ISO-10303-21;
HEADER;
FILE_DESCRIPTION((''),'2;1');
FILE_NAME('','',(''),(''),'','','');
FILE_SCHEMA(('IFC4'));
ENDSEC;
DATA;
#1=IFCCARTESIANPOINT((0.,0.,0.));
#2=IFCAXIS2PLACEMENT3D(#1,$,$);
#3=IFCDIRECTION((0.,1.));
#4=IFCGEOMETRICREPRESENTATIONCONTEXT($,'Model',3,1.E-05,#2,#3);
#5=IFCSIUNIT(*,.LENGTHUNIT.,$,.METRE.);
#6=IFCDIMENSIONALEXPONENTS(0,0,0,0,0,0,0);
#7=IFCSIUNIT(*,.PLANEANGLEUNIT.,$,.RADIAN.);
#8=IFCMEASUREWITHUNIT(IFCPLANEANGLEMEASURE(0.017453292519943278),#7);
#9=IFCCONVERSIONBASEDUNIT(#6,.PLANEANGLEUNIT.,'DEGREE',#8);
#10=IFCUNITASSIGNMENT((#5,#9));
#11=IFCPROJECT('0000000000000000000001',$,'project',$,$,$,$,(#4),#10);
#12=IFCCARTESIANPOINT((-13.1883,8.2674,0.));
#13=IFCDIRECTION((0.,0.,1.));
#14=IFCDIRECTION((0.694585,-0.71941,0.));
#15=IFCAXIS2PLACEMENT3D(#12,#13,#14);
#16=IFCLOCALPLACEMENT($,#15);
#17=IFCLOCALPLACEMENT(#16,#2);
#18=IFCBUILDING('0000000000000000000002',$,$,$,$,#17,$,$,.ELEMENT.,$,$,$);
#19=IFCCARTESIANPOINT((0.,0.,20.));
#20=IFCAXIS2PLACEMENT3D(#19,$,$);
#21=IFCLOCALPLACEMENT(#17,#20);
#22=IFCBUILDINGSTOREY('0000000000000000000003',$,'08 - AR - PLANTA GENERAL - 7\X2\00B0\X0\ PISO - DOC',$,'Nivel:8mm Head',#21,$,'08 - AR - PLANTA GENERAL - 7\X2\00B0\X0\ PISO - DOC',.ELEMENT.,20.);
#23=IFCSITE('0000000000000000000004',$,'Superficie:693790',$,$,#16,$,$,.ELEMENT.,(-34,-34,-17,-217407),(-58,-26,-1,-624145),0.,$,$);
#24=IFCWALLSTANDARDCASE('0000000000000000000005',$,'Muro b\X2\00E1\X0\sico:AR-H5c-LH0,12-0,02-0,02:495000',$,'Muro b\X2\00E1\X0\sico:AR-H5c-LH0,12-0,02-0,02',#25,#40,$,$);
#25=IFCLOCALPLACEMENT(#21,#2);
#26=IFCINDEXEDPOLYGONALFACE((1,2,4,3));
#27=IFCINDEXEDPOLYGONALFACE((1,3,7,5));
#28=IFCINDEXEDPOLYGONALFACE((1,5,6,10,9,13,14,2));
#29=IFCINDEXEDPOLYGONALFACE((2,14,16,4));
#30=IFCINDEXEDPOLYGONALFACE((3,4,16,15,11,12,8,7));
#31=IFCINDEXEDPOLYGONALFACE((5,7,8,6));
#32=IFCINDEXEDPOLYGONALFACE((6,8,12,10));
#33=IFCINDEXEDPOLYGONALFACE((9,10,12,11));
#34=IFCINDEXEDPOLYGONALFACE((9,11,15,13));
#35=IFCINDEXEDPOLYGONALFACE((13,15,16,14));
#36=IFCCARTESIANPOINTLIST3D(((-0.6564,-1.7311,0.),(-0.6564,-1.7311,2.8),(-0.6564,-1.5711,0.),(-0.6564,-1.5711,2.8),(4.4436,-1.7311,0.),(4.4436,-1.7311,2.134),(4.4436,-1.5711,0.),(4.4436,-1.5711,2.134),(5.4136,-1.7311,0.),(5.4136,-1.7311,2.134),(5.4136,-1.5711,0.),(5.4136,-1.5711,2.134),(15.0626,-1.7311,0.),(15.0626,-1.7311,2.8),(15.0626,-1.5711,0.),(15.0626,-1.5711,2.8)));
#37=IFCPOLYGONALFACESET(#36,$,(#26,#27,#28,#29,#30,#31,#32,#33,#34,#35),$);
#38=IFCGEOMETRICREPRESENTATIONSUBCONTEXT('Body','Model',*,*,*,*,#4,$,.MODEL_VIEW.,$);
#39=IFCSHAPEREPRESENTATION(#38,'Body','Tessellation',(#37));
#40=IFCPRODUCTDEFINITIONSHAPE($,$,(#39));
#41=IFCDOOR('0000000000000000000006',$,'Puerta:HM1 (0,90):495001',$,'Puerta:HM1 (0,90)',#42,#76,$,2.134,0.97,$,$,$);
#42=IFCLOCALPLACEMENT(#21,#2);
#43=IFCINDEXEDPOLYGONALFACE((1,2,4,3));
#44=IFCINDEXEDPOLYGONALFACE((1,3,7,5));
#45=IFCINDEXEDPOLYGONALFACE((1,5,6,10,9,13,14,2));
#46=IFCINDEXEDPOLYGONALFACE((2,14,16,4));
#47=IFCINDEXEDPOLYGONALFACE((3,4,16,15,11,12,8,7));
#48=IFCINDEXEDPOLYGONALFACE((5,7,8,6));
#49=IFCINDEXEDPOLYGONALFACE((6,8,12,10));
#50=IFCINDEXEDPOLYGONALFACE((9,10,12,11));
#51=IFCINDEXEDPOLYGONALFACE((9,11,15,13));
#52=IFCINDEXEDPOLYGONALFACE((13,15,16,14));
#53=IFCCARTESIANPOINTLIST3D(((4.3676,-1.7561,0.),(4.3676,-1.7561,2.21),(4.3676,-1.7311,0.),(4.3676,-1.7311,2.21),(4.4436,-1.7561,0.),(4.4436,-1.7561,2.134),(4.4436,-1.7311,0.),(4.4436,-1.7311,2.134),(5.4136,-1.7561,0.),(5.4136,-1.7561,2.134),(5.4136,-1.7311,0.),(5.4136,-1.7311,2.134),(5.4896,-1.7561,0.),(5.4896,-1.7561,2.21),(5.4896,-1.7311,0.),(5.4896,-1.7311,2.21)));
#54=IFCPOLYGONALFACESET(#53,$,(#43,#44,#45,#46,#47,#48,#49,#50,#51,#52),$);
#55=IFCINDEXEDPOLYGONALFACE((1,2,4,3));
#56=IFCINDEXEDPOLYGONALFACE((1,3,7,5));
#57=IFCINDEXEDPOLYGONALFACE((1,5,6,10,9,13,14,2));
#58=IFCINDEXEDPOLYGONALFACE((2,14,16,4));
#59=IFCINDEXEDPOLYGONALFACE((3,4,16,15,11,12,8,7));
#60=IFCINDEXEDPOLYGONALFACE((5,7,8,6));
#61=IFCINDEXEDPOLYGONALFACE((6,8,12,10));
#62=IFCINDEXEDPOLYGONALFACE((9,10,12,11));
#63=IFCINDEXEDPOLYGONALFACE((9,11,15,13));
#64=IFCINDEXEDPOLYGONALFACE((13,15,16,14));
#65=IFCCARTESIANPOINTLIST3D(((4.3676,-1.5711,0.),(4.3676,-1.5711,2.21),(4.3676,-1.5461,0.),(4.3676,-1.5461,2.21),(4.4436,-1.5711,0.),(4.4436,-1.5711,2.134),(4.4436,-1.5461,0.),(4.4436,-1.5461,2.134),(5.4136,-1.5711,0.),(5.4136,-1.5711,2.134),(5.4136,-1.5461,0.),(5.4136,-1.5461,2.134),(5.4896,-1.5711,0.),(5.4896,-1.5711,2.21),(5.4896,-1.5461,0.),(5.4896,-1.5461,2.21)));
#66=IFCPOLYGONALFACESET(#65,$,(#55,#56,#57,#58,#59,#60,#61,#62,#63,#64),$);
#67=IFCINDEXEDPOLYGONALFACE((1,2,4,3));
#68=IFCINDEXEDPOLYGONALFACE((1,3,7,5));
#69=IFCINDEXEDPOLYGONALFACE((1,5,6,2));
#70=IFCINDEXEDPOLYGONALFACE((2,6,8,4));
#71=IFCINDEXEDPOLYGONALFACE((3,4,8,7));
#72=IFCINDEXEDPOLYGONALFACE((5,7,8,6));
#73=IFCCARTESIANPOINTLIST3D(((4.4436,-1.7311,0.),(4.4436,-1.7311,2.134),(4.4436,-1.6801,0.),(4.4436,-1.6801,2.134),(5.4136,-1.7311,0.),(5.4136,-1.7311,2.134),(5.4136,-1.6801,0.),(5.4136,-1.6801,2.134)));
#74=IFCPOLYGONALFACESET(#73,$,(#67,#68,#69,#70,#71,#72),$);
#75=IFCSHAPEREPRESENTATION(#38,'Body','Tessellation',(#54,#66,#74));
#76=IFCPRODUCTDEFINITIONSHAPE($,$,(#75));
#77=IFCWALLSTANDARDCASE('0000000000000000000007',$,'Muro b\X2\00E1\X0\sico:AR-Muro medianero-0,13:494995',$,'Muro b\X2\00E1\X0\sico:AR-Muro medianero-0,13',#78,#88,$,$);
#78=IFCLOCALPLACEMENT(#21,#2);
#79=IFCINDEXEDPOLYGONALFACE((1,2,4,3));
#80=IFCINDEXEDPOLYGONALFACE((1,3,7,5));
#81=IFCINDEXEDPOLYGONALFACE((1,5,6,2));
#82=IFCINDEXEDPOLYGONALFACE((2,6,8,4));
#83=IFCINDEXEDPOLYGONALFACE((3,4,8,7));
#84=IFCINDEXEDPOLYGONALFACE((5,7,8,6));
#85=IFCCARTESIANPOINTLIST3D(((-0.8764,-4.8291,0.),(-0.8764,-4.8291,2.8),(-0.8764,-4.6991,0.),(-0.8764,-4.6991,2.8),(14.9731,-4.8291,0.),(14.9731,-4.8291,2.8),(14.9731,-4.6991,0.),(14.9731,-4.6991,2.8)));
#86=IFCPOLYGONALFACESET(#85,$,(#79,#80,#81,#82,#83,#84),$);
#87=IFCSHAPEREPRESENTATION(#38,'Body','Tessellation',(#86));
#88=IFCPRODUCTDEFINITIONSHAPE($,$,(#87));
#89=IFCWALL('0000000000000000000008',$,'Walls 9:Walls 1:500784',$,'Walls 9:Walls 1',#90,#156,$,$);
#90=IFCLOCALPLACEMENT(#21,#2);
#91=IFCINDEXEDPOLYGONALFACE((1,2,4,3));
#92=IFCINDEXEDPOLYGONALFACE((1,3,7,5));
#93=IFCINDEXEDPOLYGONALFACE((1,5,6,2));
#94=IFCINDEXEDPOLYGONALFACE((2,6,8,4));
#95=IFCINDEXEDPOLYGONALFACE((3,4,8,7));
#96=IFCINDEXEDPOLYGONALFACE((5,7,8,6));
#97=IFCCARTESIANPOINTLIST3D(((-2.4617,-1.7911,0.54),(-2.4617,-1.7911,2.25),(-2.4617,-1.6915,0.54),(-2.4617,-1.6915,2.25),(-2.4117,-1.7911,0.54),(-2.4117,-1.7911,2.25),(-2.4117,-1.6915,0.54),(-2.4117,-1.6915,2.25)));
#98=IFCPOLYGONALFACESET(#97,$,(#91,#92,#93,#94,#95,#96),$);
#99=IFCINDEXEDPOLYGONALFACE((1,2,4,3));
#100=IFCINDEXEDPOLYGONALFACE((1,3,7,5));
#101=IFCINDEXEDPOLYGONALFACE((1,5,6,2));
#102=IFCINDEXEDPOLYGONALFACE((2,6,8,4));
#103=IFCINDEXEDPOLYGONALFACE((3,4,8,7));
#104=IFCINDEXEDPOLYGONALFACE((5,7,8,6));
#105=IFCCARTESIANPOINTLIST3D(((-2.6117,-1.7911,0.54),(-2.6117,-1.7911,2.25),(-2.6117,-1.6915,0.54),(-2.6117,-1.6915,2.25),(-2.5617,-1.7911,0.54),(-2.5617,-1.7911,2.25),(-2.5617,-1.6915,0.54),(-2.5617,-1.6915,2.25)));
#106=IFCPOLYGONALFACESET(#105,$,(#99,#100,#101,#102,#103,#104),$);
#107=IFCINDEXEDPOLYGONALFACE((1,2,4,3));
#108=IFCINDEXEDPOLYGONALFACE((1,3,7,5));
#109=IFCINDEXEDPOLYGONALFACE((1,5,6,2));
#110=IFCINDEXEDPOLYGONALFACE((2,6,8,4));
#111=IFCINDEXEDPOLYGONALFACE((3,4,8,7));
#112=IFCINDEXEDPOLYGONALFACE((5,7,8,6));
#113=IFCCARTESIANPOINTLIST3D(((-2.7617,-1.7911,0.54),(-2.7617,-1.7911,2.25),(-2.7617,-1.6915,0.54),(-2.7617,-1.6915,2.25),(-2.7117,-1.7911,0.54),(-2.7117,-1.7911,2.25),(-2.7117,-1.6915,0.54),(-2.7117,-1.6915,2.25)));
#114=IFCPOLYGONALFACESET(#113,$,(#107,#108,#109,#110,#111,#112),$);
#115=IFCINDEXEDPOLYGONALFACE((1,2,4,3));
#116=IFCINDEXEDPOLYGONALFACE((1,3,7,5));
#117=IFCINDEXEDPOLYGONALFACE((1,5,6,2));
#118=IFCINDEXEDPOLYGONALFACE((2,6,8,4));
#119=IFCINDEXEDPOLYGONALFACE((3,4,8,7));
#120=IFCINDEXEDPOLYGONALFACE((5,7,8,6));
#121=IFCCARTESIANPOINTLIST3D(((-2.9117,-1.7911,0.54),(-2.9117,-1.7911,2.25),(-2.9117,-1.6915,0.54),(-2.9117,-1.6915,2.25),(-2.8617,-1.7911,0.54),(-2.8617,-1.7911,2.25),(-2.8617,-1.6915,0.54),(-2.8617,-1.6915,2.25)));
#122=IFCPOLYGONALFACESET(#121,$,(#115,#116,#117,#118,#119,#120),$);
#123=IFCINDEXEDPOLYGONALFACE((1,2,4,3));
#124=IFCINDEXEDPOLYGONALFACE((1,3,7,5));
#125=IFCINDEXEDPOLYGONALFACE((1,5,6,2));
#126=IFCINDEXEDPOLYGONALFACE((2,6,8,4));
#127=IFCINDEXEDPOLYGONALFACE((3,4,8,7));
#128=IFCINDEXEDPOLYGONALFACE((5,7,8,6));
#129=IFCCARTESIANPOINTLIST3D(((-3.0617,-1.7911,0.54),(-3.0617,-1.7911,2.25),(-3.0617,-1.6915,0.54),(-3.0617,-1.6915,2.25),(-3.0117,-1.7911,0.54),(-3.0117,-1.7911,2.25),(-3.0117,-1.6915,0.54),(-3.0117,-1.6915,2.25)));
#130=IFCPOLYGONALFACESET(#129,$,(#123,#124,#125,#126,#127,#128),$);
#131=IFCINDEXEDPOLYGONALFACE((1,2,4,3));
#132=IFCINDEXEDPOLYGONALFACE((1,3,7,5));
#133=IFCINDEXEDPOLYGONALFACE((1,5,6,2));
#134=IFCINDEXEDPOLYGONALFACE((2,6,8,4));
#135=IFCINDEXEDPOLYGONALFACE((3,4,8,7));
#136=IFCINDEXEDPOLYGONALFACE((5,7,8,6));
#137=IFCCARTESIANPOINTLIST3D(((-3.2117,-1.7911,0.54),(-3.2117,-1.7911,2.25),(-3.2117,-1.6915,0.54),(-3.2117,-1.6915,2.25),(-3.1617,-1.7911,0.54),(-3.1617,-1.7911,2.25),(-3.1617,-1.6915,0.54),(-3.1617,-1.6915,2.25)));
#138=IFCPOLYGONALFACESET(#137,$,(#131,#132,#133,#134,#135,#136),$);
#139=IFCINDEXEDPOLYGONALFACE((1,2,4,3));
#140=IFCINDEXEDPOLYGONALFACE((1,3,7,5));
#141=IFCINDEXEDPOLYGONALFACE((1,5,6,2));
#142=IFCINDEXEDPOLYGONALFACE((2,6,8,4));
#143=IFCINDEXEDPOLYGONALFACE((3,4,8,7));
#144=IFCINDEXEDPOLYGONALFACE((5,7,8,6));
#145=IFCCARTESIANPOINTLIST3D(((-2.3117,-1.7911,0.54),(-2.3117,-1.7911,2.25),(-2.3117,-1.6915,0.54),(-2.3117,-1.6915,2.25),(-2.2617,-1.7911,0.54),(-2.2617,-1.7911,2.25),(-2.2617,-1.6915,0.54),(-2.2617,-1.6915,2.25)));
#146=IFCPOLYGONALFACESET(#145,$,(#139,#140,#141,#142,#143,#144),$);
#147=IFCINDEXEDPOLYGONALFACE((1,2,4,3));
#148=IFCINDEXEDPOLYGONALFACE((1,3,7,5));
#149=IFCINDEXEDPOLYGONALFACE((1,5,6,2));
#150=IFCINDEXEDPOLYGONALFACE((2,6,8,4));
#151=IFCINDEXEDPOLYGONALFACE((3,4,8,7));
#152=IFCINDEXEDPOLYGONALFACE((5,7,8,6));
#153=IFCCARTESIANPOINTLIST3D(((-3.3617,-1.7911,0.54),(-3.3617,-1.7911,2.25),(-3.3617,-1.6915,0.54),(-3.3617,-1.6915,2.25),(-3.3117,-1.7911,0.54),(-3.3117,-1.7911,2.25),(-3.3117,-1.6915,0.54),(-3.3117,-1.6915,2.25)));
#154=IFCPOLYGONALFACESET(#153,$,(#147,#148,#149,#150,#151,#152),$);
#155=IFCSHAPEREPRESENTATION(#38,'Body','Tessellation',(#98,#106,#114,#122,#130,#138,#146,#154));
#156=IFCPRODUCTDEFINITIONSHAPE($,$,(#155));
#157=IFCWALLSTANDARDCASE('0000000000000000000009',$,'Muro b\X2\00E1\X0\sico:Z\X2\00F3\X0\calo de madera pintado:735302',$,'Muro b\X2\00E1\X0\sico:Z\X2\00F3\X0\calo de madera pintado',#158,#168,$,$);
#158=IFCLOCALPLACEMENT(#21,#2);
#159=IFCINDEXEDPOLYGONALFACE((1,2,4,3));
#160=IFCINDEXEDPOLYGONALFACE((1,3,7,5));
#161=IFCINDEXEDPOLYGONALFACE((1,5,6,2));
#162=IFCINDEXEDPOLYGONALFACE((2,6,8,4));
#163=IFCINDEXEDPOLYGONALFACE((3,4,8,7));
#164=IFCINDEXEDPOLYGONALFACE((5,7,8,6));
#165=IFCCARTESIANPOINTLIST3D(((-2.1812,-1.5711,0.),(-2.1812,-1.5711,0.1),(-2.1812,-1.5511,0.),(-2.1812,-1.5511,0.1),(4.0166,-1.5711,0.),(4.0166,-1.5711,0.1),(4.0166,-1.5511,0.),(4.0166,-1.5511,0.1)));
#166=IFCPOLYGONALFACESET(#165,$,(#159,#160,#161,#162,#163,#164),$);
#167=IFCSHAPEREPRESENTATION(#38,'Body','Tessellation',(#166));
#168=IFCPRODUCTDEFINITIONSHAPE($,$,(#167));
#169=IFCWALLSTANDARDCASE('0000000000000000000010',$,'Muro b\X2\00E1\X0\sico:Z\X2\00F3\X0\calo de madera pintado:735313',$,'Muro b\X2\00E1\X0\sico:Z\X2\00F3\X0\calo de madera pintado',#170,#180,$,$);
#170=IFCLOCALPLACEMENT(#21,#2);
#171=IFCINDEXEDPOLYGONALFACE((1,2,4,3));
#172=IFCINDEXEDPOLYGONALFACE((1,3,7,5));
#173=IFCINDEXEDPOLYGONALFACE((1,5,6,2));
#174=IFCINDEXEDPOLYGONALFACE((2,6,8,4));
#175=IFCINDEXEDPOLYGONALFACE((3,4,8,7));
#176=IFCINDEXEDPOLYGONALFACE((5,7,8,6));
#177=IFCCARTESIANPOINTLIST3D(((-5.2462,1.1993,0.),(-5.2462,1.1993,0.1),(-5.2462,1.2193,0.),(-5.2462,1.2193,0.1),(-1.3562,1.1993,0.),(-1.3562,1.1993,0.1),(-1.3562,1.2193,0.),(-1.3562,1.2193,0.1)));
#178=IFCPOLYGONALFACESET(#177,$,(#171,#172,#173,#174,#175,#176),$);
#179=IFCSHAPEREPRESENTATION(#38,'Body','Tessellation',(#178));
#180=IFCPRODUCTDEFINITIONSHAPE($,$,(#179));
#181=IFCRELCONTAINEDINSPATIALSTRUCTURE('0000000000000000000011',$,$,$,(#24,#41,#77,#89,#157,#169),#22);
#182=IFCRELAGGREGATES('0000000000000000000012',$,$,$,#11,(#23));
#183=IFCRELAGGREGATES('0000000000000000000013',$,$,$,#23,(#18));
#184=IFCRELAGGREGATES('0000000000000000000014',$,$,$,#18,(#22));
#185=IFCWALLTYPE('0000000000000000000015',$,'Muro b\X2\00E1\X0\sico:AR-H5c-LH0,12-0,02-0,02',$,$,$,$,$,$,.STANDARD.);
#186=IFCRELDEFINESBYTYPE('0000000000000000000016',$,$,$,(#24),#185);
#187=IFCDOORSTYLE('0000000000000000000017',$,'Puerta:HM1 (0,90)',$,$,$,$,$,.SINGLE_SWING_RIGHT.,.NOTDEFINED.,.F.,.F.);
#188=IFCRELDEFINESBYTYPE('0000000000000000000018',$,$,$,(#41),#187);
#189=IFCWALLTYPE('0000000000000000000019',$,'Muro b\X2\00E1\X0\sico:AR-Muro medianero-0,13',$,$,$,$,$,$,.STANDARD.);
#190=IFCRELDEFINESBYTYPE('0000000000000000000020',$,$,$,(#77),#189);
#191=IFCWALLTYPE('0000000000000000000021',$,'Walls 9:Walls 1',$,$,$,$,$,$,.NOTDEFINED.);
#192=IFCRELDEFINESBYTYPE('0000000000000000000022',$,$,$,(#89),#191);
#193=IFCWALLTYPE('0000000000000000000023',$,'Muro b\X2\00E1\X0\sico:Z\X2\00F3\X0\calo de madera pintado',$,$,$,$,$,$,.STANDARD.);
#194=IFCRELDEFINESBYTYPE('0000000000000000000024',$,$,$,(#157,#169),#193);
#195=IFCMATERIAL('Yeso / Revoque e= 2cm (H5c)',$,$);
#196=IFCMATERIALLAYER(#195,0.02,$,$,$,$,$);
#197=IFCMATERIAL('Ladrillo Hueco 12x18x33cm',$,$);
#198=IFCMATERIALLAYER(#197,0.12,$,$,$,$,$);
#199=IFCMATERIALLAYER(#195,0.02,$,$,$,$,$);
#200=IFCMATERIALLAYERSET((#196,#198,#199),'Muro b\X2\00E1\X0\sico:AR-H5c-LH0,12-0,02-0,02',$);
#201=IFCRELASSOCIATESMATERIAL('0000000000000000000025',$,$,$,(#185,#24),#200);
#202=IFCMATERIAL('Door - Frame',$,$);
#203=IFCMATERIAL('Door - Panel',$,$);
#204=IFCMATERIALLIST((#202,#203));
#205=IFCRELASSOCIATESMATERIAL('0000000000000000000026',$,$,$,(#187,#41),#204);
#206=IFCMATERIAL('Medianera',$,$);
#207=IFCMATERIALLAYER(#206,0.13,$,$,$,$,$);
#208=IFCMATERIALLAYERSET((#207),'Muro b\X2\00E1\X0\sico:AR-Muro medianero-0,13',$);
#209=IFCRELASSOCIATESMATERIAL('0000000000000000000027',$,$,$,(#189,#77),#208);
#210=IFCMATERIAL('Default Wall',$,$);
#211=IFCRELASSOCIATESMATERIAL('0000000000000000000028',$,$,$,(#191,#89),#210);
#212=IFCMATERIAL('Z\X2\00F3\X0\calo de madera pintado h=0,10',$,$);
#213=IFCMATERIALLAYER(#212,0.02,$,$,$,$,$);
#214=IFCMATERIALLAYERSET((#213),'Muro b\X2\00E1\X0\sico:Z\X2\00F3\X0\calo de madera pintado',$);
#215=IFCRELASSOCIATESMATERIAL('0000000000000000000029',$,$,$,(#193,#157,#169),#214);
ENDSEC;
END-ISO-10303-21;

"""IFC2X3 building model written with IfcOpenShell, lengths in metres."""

from ifc_helpers import new_model, entity, si_unit, converted_unit, direction, frame, frame_2d, origin, place, context, subcontext, project, spatial, polyline, rectangle, outline, extrude, source, transform, mapped, material, material_list, layer, layer_set, layer_usage, type_object, type_shapes, element, fill, save


model = new_model("IFC2X3")

# Units and contexts
model_context = context("Model", 3, precision=1e-05, world=origin(), true_north=direction((0.0, 1.0)))
body_context = subcontext(model_context, "Body", "Model", "MODEL_VIEW")
ifc_project = project(units=[si_unit("LENGTHUNIT", "METRE"), converted_unit("PLANEANGLEUNIT", "DEGREE", entity("IfcPlaneAngleMeasure", 0.017453292519943278), si_unit("PLANEANGLEUNIT", "RADIAN"), dimensions=[0, 0, 0, 0, 0, 0, 0])], contexts=[model_context])

# Site, building, storey
site_placement = place(None, frame((-13.1883, 8.2674, 0.0), z_axis=(0.0, 0.0, 1.0), x_axis=(0.694585, -0.71941, 0.0)))
site = spatial("IfcSite", under=ifc_project, at=site_placement, Name="Superficie:693790", CompositionType="ELEMENT", RefLatitude=(-34, -34, -17, -217407), RefLongitude=(-58, -26, -1, -624145), RefElevation=0.0)
building_placement = place(site_placement, origin())
building = spatial("IfcBuilding", under=site, at=building_placement, CompositionType="ELEMENT")
storey_placement = place(building_placement, frame((0.0, 0.0, 20.0)))
storey = spatial("IfcBuildingStorey", under=building, at=storey_placement, Name="08 - AR - PLANTA GENERAL - 7° PISO - DOC", ObjectType="Nivel:8mm Head", LongName="08 - AR - PLANTA GENERAL - 7° PISO - DOC", CompositionType="ELEMENT", Elevation=20.0)

# Wall, opening, door
ifc_material_1 = material(Name="Yeso / Revoque e= 2cm (H5c)")
ifc_layer_1 = layer(ifc_material_1, 0.02)
ifc_material_2 = material(Name="Ladrillo Hueco 12x18x33cm")
ifc_layer_2 = layer(ifc_material_2, 0.12)
ifc_layer_3 = layer(ifc_material_1, 0.02)
ifc_layer_set_1 = layer_set([ifc_layer_1, ifc_layer_2, ifc_layer_3], Name="Muro básico:AR-H5c-LH0,12-0,02-0,02")
ifc_layer_usage_1 = layer_usage(ifc_layer_set_1, "AXIS2", "NEGATIVE", 0.08)
wall_type_1 = type_object("IfcWallType", Name="Muro básico:AR-H5c-LH0,12-0,02-0,02", PredefinedType="STANDARD", material=ifc_layer_set_1)
wall_1_placement = place(storey_placement, frame((-0.6564, -1.6511, 0.0)))
wall_1 = element("IfcWallStandardCase", 1, at=wall_1_placement, inside=storey, type_object=wall_type_1, material=ifc_layer_usage_1, Name="Muro básico:AR-H5c-LH0,12-0,02-0,02:495000", ObjectType="Muro básico:AR-H5c-LH0,12-0,02-0,02", context=body_context, shape_type="SweptSolid", body=[
    extrude(rectangle(XDim=15.719, YDim=0.16, at=frame_2d((7.8595, 0.0), x_axis=(1.0, 0.0))), origin(), (0.0, 0.0, 1.0), 2.8),
])
opening_1_placement = place(wall_1_placement, frame((6.07, 0.08, 0.0)))
opening_1 = element("IfcOpeningElement", 2, at=opening_1_placement, cuts=wall_1, ObjectType="Opening", context=body_context, shape_type="SweptSolid", body=[
    extrude(rectangle(XDim=0.97, YDim=2.134, at=frame_2d((1.067, 0.485), x_axis=(0.0, 1.0))), frame((0.0, 0.0, 0.0), z_axis=(0.0, -1.0, 0.0), x_axis=(0.0, 0.0, 1.0)), (0.0, 0.0, 1.0), 0.16),
])
ifc_material_3 = material(Name="Door - Frame")
ifc_material_4 = material(Name="Door - Panel")
ifc_material_list_1 = material_list([ifc_material_3, ifc_material_4])
door_style = type_object("IfcDoorStyle", Name="Puerta:HM1 (0,90)", ConstructionType="NOTDEFINED", OperationType="SINGLE_SWING_RIGHT", ParameterTakesPrecedence=False, Sizeable=False, material=ifc_material_list_1)
shared_shape_1 = source(origin(), body_context, "Body", "SweptSolid", [
    extrude(outline(polyline([(-0.561, -1.124), (0.561, -1.124), (0.561, 1.086), (0.485, 1.086), (0.485, -1.048), (-0.485, -1.048), (-0.485, 1.086), (-0.561, 1.086), (-0.561, -1.124)])), frame((0.485, 0.16, 1.086), z_axis=(0.0, 1.0, 0.0), x_axis=(1.0, 0.0, 0.0)), (0.0, 0.0, 1.0), 0.025),
    extrude(outline(polyline([(-1.124, -0.561), (1.086, -0.561), (1.086, -0.485), (-1.048, -0.485), (-1.048, 0.485), (1.086, 0.485), (1.086, 0.561), (-1.124, 0.561), (-1.124, -0.561)])), frame((0.485, -0.025, 1.086), z_axis=(0.0, 1.0, 0.0), x_axis=(0.0, 0.0, -1.0)), (0.0, 0.0, 1.0), 0.025),
    extrude(rectangle(XDim=0.051, YDim=0.97, at=frame_2d((0.0, 0.0), x_axis=(1.0, 0.0))), frame((0.485, 0.1345, 0.0), z_axis=(0.0, 0.0, 1.0), x_axis=(0.0, 1.0, 0.0)), (0.0, 0.0, 1.0), 2.134),
])
type_shapes(door_style, [shared_shape_1])
door_placement = place(opening_1_placement, frame((0.0, 0.0, 0.0), z_axis=(0.0, 0.0, 1.0), x_axis=(-1.0, 0.0, 0.0)))
door = element("IfcDoor", 3, at=door_placement, inside=storey, type_object=door_style, material=ifc_material_list_1, Name="Puerta:HM1 (0,90):495001", ObjectType="Puerta:HM1 (0,90)", OverallHeight=2.134, OverallWidth=0.97, context=body_context, shape_type="MappedRepresentation", body=[
    mapped(shared_shape_1, transform((0.0, 0.0, 0.0), scale=1.0)),
])
fill(opening_1, door)

# Walls
ifc_material_5 = material(Name="Medianera")
ifc_layer_4 = layer(ifc_material_5, 0.13)
ifc_layer_set_2 = layer_set([ifc_layer_4], Name="Muro básico:AR-Muro medianero-0,13")
ifc_layer_usage_2 = layer_usage(ifc_layer_set_2, "AXIS2", "POSITIVE", -0.065)
wall_type_2 = type_object("IfcWallType", Name="Muro básico:AR-Muro medianero-0,13", PredefinedType="STANDARD", material=ifc_layer_set_2)
wall_2_placement = place(storey_placement, frame((-0.8764, -4.7641, 0.0)))
element("IfcWallStandardCase", 4, at=wall_2_placement, inside=storey, type_object=wall_type_2, material=ifc_layer_usage_2, Name="Muro básico:AR-Muro medianero-0,13:494995", ObjectType="Muro básico:AR-Muro medianero-0,13", context=body_context, shape_type="SweptSolid", body=[
    extrude(rectangle(XDim=15.8495, YDim=0.13, at=frame_2d((7.9247, 0.0), x_axis=(-1.0, 0.0))), origin(), (0.0, 0.0, 1.0), 2.8),
])
ifc_material_6 = material(Name="Default Wall")
wall_type_3 = type_object("IfcWallType", Name="Walls 9:Walls 1", PredefinedType="NOTDEFINED", material=ifc_material_6)
wall_3_placement = place(storey_placement, frame((-3.3617, -1.7911, 0.54)))
element("IfcWall", 5, at=wall_3_placement, inside=storey, type_object=wall_type_3, material=ifc_material_6, Name="Walls 9:Walls 1:500784", ObjectType="Walls 9:Walls 1", context=body_context, shape_type="SweptSolid", body=[
    extrude(rectangle(XDim=0.05, YDim=0.0996, at=frame_2d((0.0, 0.0), x_axis=(1.0, 0.0))), frame((0.925, 0.0498, 0.0), z_axis=(0.0, 0.0, 1.0), x_axis=(-1.0, 0.0, 0.0)), (0.0, 0.0, 1.0), 1.71),
    extrude(rectangle(XDim=0.05, YDim=0.0996, at=frame_2d((0.0, 0.0), x_axis=(1.0, 0.0))), frame((0.775, 0.0498, 0.0), z_axis=(0.0, 0.0, 1.0), x_axis=(-1.0, 0.0, 0.0)), (0.0, 0.0, 1.0), 1.71),
    extrude(rectangle(XDim=0.05, YDim=0.0996, at=frame_2d((0.0, 0.0), x_axis=(1.0, 0.0))), frame((0.625, 0.0498, 0.0), z_axis=(0.0, 0.0, 1.0), x_axis=(-1.0, 0.0, 0.0)), (0.0, 0.0, 1.0), 1.71),
    extrude(rectangle(XDim=0.05, YDim=0.0996, at=frame_2d((0.0, 0.0), x_axis=(1.0, 0.0))), frame((0.475, 0.0498, 0.0), z_axis=(0.0, 0.0, 1.0), x_axis=(-1.0, 0.0, 0.0)), (0.0, 0.0, 1.0), 1.71),
    extrude(rectangle(XDim=0.05, YDim=0.0996, at=frame_2d((0.0, 0.0), x_axis=(1.0, 0.0))), frame((0.325, 0.0498, 0.0), z_axis=(0.0, 0.0, 1.0), x_axis=(-1.0, 0.0, 0.0)), (0.0, 0.0, 1.0), 1.71),
    extrude(rectangle(XDim=0.05, YDim=0.0996, at=frame_2d((0.0, 0.0), x_axis=(1.0, 0.0))), frame((0.175, 0.0498, 0.0), z_axis=(0.0, 0.0, 1.0), x_axis=(-1.0, 0.0, 0.0)), (0.0, 0.0, 1.0), 1.71),
    extrude(rectangle(XDim=0.05, YDim=0.0996, at=frame_2d((0.0, 0.0), x_axis=(1.0, 0.0))), frame((1.075, 0.0498, 0.0), z_axis=(0.0, 0.0, 1.0), x_axis=(-1.0, 0.0, 0.0)), (0.0, 0.0, 1.0), 1.71),
    extrude(rectangle(XDim=0.05, YDim=0.0996, at=frame_2d((0.0, 0.0), x_axis=(1.0, 0.0))), frame((0.025, 0.0498, 0.0), z_axis=(0.0, 0.0, 1.0), x_axis=(-1.0, 0.0, 0.0)), (0.0, 0.0, 1.0), 1.71),
])
ifc_material_7 = material(Name="Zócalo de madera pintado h=0,10")
ifc_layer_5 = layer(ifc_material_7, 0.02)
ifc_layer_set_3 = layer_set([ifc_layer_5], Name="Muro básico:Zócalo de madera pintado")
ifc_layer_usage_3 = layer_usage(ifc_layer_set_3, "AXIS2", "NEGATIVE", 0.01)
wall_type_4 = type_object("IfcWallType", Name="Muro básico:Zócalo de madera pintado", PredefinedType="STANDARD", material=ifc_layer_set_3)
wall_4_placement = place(storey_placement, frame((-2.1812, -1.5611, 0.0)))
element("IfcWallStandardCase", 6, at=wall_4_placement, inside=storey, type_object=wall_type_4, material=ifc_layer_usage_3, Name="Muro básico:Zócalo de madera pintado:735302", ObjectType="Muro básico:Zócalo de madera pintado", context=body_context, shape_type="SweptSolid", body=[
    extrude(rectangle(XDim=6.1979, YDim=0.02, at=frame_2d((3.0989, 0.0), x_axis=(-1.0, 0.0))), origin(), (0.0, 0.0, 1.0), 0.1),
])
ifc_layer_usage_4 = layer_usage(ifc_layer_set_3, "AXIS2", "NEGATIVE", 0.01)
wall_5_placement = place(storey_placement, frame((-1.3562, 1.2093, 0.0), z_axis=(0.0, 0.0, 1.0), x_axis=(-1.0, 0.0, 0.0)))
element("IfcWallStandardCase", 7, at=wall_5_placement, inside=storey, type_object=wall_type_4, material=ifc_layer_usage_4, Name="Muro básico:Zócalo de madera pintado:735313", ObjectType="Muro básico:Zócalo de madera pintado", context=body_context, shape_type="SweptSolid", body=[
    extrude(rectangle(XDim=3.89, YDim=0.02, at=frame_2d((1.945, 0.0), x_axis=(-1.0, 0.0))), origin(), (0.0, 0.0, 1.0), 0.1),
])

save(model, "model.ifc")
